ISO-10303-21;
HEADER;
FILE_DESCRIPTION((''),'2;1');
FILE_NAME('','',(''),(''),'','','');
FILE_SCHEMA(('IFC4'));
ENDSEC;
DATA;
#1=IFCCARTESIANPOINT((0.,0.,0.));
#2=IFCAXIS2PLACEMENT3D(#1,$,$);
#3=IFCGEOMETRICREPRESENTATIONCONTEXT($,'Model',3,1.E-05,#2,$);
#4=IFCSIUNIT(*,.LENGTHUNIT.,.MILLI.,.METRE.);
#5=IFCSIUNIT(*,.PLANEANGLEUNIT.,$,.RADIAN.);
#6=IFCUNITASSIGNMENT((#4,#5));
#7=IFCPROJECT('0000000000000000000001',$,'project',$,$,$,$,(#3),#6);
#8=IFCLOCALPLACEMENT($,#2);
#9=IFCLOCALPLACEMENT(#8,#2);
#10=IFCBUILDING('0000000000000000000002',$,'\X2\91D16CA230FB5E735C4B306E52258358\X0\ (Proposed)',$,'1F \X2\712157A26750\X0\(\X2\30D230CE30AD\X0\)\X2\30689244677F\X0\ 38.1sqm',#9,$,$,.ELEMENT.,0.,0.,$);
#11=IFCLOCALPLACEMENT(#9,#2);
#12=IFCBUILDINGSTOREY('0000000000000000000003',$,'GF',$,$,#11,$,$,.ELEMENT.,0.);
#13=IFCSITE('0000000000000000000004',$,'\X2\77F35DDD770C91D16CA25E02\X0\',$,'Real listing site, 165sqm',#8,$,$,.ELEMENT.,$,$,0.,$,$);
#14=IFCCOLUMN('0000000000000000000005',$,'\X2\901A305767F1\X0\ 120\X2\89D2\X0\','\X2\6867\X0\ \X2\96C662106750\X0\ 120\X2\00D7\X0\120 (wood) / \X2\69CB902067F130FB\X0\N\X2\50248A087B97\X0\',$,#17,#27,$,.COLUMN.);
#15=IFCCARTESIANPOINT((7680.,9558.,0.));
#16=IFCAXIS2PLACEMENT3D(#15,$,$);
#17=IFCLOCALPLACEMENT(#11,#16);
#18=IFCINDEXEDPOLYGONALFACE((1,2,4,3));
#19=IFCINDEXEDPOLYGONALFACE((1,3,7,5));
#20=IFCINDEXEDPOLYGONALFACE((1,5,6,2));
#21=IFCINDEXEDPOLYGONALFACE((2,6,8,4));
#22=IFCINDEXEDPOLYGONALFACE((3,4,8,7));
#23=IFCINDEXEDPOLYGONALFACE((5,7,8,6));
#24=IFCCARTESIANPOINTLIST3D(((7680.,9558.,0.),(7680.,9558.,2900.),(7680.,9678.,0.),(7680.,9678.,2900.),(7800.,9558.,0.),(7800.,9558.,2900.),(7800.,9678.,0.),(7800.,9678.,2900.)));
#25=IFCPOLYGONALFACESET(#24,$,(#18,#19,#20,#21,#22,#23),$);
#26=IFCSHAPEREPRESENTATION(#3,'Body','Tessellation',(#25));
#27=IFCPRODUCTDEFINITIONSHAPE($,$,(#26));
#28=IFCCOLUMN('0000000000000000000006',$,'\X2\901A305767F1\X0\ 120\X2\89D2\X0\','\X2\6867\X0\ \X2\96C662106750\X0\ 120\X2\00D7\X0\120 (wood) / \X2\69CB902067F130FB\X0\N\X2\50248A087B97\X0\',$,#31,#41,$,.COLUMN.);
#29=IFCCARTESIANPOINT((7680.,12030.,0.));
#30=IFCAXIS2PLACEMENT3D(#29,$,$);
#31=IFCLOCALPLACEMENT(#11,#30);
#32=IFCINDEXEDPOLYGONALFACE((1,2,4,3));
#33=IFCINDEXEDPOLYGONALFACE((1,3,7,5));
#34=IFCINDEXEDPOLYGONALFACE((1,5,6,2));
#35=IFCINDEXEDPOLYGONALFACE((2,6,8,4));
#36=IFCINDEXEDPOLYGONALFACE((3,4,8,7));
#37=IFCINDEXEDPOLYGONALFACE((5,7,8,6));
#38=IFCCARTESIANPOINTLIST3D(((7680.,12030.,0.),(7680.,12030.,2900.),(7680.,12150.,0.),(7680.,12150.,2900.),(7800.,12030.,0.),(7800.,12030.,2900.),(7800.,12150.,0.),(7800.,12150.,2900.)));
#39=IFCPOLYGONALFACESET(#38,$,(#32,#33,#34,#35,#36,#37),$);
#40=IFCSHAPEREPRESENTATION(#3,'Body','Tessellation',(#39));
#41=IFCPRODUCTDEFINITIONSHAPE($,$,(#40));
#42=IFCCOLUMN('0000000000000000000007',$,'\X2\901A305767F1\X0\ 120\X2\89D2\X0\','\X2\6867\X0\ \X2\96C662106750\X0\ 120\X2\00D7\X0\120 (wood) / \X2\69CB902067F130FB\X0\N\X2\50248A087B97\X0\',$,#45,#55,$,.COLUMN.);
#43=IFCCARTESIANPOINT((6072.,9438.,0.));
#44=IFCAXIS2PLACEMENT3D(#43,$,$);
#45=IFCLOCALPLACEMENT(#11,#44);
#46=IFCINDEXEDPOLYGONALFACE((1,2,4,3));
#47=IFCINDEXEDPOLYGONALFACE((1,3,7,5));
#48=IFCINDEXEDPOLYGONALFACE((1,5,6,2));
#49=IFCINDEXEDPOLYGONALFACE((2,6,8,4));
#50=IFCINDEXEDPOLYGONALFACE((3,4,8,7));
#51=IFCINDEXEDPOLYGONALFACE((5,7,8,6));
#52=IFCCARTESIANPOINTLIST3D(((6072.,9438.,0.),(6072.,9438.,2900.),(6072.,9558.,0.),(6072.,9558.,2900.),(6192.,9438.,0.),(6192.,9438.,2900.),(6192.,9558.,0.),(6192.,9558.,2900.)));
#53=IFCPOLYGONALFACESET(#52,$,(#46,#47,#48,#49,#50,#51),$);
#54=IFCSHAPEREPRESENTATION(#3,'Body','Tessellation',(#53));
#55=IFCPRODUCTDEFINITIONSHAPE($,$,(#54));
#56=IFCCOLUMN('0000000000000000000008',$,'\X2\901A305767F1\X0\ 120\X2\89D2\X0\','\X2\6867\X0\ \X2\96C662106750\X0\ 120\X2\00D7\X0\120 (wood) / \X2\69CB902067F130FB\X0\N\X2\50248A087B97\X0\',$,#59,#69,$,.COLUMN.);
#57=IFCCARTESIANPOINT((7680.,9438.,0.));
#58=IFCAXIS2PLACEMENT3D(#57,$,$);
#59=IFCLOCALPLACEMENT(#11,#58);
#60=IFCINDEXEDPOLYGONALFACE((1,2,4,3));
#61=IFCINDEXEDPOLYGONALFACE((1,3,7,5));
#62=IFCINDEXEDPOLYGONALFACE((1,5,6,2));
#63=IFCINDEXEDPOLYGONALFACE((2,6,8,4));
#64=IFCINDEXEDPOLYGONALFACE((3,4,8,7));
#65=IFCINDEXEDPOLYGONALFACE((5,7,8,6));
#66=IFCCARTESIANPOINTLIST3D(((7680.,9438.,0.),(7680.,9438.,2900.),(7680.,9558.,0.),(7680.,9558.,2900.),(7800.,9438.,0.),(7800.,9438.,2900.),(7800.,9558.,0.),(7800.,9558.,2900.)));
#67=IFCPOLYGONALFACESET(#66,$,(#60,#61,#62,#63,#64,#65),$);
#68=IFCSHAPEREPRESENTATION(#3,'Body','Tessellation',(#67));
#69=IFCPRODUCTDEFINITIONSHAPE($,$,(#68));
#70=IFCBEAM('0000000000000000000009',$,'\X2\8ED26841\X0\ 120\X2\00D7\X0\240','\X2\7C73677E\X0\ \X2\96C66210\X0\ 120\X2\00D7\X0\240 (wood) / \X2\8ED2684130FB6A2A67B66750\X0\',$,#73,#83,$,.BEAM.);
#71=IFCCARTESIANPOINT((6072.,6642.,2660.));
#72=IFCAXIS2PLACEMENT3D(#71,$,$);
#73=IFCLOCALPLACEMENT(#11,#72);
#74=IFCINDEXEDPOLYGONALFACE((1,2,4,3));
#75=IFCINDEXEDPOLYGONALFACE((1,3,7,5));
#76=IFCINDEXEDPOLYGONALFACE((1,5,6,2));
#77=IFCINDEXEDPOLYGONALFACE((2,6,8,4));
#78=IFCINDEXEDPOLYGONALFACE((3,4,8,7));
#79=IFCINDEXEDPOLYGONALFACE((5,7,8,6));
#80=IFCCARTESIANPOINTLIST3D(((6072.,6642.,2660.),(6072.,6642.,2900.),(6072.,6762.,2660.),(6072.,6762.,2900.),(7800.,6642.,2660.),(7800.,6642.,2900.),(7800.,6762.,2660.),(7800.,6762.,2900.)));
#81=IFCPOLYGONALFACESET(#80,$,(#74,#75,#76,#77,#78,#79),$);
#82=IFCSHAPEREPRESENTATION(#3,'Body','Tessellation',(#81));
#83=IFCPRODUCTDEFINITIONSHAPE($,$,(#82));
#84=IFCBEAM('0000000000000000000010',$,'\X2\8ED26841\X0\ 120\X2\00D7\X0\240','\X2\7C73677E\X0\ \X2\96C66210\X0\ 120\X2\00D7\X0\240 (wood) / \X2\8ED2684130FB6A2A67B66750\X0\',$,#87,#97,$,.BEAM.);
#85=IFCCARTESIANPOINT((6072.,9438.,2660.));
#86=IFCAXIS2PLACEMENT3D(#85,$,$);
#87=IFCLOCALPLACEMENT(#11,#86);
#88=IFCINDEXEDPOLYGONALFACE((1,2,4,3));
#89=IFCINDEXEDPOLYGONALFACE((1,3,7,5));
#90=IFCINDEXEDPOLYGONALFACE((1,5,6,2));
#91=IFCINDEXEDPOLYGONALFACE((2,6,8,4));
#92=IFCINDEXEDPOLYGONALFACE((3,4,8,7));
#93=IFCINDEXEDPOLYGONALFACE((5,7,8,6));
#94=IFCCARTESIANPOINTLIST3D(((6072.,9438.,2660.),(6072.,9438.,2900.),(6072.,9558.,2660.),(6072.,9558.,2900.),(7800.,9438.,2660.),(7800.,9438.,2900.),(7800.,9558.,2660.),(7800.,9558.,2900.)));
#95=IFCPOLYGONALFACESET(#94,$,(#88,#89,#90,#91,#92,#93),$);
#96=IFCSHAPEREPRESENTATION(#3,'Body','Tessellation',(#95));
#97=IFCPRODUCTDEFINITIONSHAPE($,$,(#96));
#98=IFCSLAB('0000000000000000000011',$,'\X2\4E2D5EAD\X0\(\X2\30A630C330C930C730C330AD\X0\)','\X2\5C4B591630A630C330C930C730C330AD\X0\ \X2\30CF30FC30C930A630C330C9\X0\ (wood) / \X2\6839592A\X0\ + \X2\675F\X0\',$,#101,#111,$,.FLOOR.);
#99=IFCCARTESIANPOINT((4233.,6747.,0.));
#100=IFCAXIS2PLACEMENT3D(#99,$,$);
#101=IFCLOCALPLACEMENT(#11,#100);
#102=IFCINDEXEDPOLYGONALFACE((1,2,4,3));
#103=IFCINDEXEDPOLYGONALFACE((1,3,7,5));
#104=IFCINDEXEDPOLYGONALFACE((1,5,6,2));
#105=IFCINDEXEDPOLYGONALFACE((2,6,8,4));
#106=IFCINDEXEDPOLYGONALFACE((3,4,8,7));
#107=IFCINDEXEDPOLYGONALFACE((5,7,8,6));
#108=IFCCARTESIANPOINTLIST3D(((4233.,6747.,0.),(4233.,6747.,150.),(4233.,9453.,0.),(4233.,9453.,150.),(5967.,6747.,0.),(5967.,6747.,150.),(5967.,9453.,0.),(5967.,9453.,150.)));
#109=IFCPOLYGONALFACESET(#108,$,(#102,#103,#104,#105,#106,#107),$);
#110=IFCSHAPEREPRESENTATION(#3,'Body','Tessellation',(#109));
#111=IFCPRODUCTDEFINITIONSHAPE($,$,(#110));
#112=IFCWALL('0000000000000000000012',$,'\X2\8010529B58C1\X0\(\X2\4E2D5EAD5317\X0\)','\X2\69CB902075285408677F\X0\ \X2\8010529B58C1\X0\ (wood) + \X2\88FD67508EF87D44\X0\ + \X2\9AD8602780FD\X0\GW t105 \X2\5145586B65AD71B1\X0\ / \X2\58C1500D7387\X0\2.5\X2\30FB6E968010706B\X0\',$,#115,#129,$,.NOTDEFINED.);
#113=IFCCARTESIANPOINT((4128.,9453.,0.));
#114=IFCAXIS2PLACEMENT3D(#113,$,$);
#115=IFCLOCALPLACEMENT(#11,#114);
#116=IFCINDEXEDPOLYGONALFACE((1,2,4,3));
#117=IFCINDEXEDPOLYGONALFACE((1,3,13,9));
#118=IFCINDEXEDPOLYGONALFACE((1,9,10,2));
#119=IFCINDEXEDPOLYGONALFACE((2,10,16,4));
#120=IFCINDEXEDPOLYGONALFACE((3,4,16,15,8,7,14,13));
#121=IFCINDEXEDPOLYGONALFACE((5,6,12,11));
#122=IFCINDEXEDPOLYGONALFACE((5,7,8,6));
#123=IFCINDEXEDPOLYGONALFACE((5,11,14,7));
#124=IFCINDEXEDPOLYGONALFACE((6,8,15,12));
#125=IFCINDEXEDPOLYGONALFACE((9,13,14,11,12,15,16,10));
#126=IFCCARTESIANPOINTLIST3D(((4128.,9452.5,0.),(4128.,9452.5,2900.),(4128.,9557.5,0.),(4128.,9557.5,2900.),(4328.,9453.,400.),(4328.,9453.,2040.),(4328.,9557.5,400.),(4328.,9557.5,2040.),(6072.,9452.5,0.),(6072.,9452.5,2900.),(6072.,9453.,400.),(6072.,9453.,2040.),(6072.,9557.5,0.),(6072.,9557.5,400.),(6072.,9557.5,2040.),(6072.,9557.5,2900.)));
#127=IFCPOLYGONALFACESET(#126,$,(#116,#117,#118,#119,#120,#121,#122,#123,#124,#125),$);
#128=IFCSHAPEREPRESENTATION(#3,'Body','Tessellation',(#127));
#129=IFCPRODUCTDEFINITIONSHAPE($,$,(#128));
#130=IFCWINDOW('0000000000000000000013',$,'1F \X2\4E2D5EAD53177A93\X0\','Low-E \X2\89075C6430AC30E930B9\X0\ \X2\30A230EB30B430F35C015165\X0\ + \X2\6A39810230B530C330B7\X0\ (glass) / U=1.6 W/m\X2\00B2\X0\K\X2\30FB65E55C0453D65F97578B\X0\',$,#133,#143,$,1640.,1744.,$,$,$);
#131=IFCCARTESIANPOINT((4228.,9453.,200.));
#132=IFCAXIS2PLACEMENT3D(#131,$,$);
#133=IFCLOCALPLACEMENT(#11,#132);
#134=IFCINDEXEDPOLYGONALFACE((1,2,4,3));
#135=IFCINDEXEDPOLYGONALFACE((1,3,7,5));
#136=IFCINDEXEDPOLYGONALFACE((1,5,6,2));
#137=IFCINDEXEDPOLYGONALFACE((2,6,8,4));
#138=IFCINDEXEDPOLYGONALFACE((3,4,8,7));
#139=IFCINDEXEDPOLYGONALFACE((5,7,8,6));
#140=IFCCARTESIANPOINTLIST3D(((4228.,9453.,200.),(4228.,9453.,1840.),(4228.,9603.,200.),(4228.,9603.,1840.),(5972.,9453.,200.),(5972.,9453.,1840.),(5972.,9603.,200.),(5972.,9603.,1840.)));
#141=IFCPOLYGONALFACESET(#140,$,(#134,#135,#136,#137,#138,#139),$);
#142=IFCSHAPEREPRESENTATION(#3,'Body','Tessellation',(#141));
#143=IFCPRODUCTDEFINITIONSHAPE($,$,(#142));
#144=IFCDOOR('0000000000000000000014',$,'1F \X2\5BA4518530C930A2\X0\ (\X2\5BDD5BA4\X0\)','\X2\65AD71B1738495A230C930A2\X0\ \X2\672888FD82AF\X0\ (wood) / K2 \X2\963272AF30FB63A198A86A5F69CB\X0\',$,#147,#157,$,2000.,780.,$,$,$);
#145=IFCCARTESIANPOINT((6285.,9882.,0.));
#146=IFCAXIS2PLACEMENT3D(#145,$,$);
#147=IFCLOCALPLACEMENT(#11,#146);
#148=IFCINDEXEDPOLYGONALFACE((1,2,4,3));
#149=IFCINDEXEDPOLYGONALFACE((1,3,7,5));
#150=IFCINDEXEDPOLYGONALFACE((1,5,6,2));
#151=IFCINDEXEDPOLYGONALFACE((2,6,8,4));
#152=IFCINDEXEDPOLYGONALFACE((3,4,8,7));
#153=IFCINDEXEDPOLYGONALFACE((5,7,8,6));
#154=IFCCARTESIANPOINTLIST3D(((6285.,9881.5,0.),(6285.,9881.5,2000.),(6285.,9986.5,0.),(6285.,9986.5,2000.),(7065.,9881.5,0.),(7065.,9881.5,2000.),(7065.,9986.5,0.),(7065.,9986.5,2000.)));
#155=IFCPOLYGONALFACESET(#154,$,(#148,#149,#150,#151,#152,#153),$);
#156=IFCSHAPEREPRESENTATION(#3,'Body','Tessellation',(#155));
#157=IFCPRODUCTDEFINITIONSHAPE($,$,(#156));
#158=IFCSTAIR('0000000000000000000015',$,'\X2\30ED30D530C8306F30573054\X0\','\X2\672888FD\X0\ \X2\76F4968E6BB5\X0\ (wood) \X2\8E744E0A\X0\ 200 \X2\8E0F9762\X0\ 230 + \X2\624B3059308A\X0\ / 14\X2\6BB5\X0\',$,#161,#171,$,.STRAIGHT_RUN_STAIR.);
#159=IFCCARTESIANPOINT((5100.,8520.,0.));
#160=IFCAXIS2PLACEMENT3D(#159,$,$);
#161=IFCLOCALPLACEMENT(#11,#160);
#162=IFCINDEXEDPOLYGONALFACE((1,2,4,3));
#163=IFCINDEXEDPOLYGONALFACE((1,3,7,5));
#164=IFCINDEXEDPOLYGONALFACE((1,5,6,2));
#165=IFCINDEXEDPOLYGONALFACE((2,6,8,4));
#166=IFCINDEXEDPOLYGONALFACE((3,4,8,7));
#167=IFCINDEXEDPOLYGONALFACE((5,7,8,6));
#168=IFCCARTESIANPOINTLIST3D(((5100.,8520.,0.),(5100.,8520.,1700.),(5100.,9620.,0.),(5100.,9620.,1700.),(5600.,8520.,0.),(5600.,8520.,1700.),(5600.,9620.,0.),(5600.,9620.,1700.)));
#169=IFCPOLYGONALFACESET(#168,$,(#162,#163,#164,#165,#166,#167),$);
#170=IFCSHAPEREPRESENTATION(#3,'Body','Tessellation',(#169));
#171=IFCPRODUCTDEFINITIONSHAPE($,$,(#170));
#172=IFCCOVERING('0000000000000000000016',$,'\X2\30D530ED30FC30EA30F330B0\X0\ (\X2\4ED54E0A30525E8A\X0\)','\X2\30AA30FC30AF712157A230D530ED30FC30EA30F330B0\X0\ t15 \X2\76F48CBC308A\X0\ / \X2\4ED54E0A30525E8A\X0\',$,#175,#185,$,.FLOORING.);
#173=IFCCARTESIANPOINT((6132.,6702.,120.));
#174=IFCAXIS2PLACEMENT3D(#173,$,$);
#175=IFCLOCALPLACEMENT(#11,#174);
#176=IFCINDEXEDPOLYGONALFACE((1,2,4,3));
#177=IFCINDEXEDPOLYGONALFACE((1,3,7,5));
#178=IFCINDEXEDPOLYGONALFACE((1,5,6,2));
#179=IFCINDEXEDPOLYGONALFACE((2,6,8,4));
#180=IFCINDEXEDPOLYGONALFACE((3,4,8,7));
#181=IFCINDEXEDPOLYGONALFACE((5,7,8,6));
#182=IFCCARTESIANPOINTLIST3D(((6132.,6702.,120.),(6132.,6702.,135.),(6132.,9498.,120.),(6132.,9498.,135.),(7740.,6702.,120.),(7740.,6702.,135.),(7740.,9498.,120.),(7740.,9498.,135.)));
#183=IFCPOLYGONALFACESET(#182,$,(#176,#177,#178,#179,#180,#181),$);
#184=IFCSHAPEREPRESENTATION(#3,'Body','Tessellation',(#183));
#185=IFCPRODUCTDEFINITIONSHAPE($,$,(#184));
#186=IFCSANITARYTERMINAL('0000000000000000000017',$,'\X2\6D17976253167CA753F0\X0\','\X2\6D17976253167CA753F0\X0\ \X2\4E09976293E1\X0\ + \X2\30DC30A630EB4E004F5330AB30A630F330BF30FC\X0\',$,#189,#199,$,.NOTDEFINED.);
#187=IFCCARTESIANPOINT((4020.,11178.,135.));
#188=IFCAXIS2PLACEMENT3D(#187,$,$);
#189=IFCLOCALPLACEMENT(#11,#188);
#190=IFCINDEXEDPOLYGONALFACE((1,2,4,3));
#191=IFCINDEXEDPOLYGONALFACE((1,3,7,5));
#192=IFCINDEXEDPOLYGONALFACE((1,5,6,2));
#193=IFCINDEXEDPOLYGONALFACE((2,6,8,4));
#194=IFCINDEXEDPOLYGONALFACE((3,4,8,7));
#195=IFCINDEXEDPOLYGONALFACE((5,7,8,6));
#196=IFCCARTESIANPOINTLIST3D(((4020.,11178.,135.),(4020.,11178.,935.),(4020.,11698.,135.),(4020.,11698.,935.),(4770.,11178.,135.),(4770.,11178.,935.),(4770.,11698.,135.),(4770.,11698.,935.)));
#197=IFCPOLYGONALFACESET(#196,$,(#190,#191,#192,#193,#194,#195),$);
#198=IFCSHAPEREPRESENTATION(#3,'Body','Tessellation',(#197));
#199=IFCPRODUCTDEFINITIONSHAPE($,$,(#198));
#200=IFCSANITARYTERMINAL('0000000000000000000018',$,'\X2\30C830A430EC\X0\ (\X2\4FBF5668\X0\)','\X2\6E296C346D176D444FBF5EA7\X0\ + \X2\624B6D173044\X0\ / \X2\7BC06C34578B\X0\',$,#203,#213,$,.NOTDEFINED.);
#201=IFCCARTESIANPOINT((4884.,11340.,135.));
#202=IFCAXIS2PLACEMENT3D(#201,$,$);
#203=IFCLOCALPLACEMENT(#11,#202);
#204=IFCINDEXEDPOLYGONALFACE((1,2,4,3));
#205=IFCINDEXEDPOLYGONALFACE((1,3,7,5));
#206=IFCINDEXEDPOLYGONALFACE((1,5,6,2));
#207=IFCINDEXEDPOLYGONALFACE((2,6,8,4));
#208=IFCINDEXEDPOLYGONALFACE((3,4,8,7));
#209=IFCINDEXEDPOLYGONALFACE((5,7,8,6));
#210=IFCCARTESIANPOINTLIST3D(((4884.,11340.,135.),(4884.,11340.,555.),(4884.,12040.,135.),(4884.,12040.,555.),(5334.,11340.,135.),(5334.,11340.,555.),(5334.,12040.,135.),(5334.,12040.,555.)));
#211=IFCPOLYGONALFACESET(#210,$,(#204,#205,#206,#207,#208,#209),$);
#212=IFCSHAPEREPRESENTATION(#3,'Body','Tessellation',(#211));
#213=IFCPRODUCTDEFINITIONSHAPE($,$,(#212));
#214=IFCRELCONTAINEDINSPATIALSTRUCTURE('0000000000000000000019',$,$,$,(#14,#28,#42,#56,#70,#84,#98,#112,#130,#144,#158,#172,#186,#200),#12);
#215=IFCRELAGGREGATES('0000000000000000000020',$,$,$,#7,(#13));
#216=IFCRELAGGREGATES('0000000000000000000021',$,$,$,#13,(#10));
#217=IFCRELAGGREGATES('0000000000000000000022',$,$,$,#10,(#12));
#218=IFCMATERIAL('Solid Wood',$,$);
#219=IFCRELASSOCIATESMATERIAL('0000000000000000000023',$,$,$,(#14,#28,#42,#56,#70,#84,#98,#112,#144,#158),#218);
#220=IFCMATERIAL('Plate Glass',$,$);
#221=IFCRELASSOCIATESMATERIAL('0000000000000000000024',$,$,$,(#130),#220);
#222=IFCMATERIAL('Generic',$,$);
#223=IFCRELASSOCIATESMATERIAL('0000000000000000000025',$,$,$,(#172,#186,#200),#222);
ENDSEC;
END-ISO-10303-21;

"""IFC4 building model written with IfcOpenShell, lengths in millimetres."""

from ifc_helpers import new_model, si_unit, frame, frame_2d, origin, place, context, project, spatial, rectangle, extrude, material, element, fill, save


model = new_model("IFC4")

# Units and contexts
model_context = context("Model", 3, precision=1e-05, world=origin())
ifc_project = project(units=[si_unit("LENGTHUNIT", "METRE", prefix="MILLI"), si_unit("PLANEANGLEUNIT", "RADIAN")], contexts=[model_context])

# Site, building, storey
site_placement = place(None, origin())
site = spatial("IfcSite", under=ifc_project, at=site_placement, Name="石川県金沢市", ObjectType="Real listing site, 165sqm", CompositionType="ELEMENT", RefElevation=0.0)
building_placement = place(site_placement, origin())
building = spatial("IfcBuilding", under=site, at=building_placement, Name="金沢・平屋の別荘 (Proposed)", ObjectType="1F 無垢材(ヒノキ)と鉄板 38.1sqm", CompositionType="ELEMENT", ElevationOfRefHeight=0.0, ElevationOfTerrain=0.0)
storey_placement = place(building_placement, origin())
storey = spatial("IfcBuildingStorey", under=building, at=storey_placement, Name="GF", CompositionType="ELEMENT", Elevation=0.0)

# Columns
ifc_material_1 = material(Name="Solid Wood")
column_1_placement = place(storey_placement, frame((7680.0, 9558.0, 0.0)))
element("IfcColumn", 1, at=column_1_placement, inside=storey, material=ifc_material_1, Name="通し柱 120角", Description="桧 集成材 120×120 (wood) / 構造柱・N値計算", PredefinedType="COLUMN", context=model_context, shape_type="SweptSolid", body=[
    extrude(rectangle(XDim=120.0, YDim=120.0, at=frame_2d((60.0, 60.0))), frame((7680.0, 9558.0, 0.0)), (0.0, 0.0, 1.0), 2900.0),
])
column_2_placement = place(storey_placement, frame((7680.0, 12030.0, 0.0)))
element("IfcColumn", 2, at=column_2_placement, inside=storey, material=ifc_material_1, Name="通し柱 120角", Description="桧 集成材 120×120 (wood) / 構造柱・N値計算", PredefinedType="COLUMN", context=model_context, shape_type="SweptSolid", body=[
    extrude(rectangle(XDim=120.0, YDim=120.0, at=frame_2d((60.0, 60.0))), frame((7680.0, 12030.0, 0.0)), (0.0, 0.0, 1.0), 2900.0),
])
column_3_placement = place(storey_placement, frame((6072.0, 9438.0, 0.0)))
element("IfcColumn", 3, at=column_3_placement, inside=storey, material=ifc_material_1, Name="通し柱 120角", Description="桧 集成材 120×120 (wood) / 構造柱・N値計算", PredefinedType="COLUMN", context=model_context, shape_type="SweptSolid", body=[
    extrude(rectangle(XDim=120.0, YDim=120.0, at=frame_2d((60.0, 60.0))), frame((6072.0, 9438.0, 0.0)), (0.0, 0.0, 1.0), 2900.0),
])
column_4_placement = place(storey_placement, frame((7680.0, 9438.0, 0.0)))
element("IfcColumn", 4, at=column_4_placement, inside=storey, material=ifc_material_1, Name="通し柱 120角", Description="桧 集成材 120×120 (wood) / 構造柱・N値計算", PredefinedType="COLUMN", context=model_context, shape_type="SweptSolid", body=[
    extrude(rectangle(XDim=120.0, YDim=120.0, at=frame_2d((60.0, 60.0))), frame((7680.0, 9438.0, 0.0)), (0.0, 0.0, 1.0), 2900.0),
])

# Beams
beam_1_placement = place(storey_placement, frame((6072.0, 6642.0, 2660.0)))
element("IfcBeam", 5, at=beam_1_placement, inside=storey, material=ifc_material_1, Name="軒桁 120×240", Description="米松 集成 120×240 (wood) / 軒桁・横架材", PredefinedType="BEAM", context=model_context, shape_type="SweptSolid", body=[
    extrude(rectangle(XDim=1728.0, YDim=120.0, at=frame_2d((864.0, 60.0))), frame((6072.0, 6642.0, 2660.0)), (0.0, 0.0, 1.0), 240.0),
])
beam_2_placement = place(storey_placement, frame((6072.0, 9438.0, 2660.0)))
element("IfcBeam", 6, at=beam_2_placement, inside=storey, material=ifc_material_1, Name="軒桁 120×240", Description="米松 集成 120×240 (wood) / 軒桁・横架材", PredefinedType="BEAM", context=model_context, shape_type="SweptSolid", body=[
    extrude(rectangle(XDim=1728.0, YDim=120.0, at=frame_2d((864.0, 60.0))), frame((6072.0, 9438.0, 2660.0)), (0.0, 0.0, 1.0), 240.0),
])

# Slab
slab_placement = place(storey_placement, frame((4233.0, 6747.0, 0.0)))
element("IfcSlab", 7, at=slab_placement, inside=storey, material=ifc_material_1, Name="中庭(ウッドデッキ)", Description="屋外ウッドデッキ ハードウッド (wood) / 根太 + 束", PredefinedType="FLOOR", context=model_context, shape_type="SweptSolid", body=[
    extrude(rectangle(XDim=1734.0, YDim=2706.0, at=frame_2d((867.0, 1353.0))), frame((4233.0, 6747.0, 0.0)), (0.0, 0.0, 1.0), 150.0),
])

# Wall, opening, window
wall_1_placement = place(storey_placement, frame((4128.0, 9453.0, 0.0)))
wall_1 = element("IfcWall", 8, at=wall_1_placement, inside=storey, material=ifc_material_1, Name="耐力壁(中庭北)", Description="構造用合板 耐力壁 (wood) + 製材軸組 + 高性能GW t105 充填断熱 / 壁倍率2.5・準耐火", PredefinedType="NOTDEFINED", context=model_context, shape_type="SweptSolid", body=[
    extrude(rectangle(XDim=1944.0, YDim=105.0, at=frame_2d((972.0, 52.0))), frame((4128.0, 9453.0, 0.0)), (0.0, 0.0, 1.0), 2900.0),
])
opening_placement = place(storey_placement, frame((4228.0, 9453.0, 200.0)))
opening = element("IfcOpeningElement", 9, at=opening_placement, cuts=wall_1, PredefinedType="NOTDEFINED", context=model_context, shape_type="SweptSolid", body=[
    extrude(rectangle(XDim=1744.0, YDim=150.0, at=frame_2d((872.0, 75.0))), frame((4228.0, 9453.0, 200.0)), (0.0, 0.0, 1.0), 1640.0),
])
ifc_material_2 = material(Name="Plate Glass")
window_placement = place(storey_placement, frame((4228.0, 9453.0, 200.0)))
window = element("IfcWindow", 10, at=window_placement, inside=storey, material=ifc_material_2, Name="1F 中庭北窓", Description="Low-E 複層ガラス アルゴン封入 + 樹脂サッシ (glass) / U=1.6 W/m²K・日射取得型", OverallHeight=1640.0, OverallWidth=1744.0, context=model_context, shape_type="SweptSolid", body=[
    extrude(rectangle(XDim=1744.0, YDim=150.0, at=frame_2d((872.0, 75.0))), frame((4228.0, 9453.0, 200.0)), (0.0, 0.0, 1.0), 1640.0),
])
fill(opening, window)

# Door
door_placement = place(storey_placement, frame((6285.0, 9882.0, 0.0)))
element("IfcDoor", 11, at=door_placement, inside=storey, material=ifc_material_1, Name="1F 室内ドア (寝室)", Description="断熱玄関ドア 木製芯 (wood) / K2 防犯・採風機構", OverallHeight=2000.0, OverallWidth=780.0, context=model_context, shape_type="SweptSolid", body=[
    extrude(rectangle(XDim=780.0, YDim=105.0, at=frame_2d((390.0, 52.0))), frame((6285.0, 9882.0, 0.0)), (0.0, 0.0, 1.0), 2000.0),
])

# Stair
stair_placement = place(storey_placement, frame((5100.0, 8520.0, 0.0)))
element("IfcStair", 12, at=stair_placement, inside=storey, material=ifc_material_1, Name="ロフトはしご", Description="木製 直階段 (wood) 蹴上 200 踏面 230 + 手すり / 14段", PredefinedType="STRAIGHT_RUN_STAIR", context=model_context, shape_type="SweptSolid", body=[
    extrude(rectangle(XDim=500.0, YDim=1100.0, at=frame_2d((250.0, 550.0))), frame((5100.0, 8520.0, 0.0)), (0.0, 0.0, 1.0), 1700.0),
])

# Covering
ifc_material_3 = material(Name="Generic")
covering_placement = place(storey_placement, frame((6132.0, 6702.0, 120.0)))
element("IfcCovering", 13, at=covering_placement, inside=storey, material=ifc_material_3, Name="フローリング (仕上げ床)", Description="オーク無垢フローリング t15 直貼り / 仕上げ床", PredefinedType="FLOORING", context=model_context, shape_type="SweptSolid", body=[
    extrude(rectangle(XDim=1608.0, YDim=2796.0, at=frame_2d((804.0, 1398.0))), frame((6132.0, 6702.0, 120.0)), (0.0, 0.0, 1.0), 15.0),
])

# Sanitary terminals
sanitary_terminal_1_placement = place(storey_placement, frame((4020.0, 11178.0, 135.0)))
element("IfcSanitaryTerminal", 14, at=sanitary_terminal_1_placement, inside=storey, material=ifc_material_3, Name="洗面化粧台", Description="洗面化粧台 三面鏡 + ボウル一体カウンター", PredefinedType="NOTDEFINED", context=model_context, shape_type="SweptSolid", body=[
    extrude(rectangle(XDim=750.0, YDim=520.0, at=frame_2d((375.0, 260.0))), frame((4020.0, 11178.0, 135.0)), (0.0, 0.0, 1.0), 800.0),
])
sanitary_terminal_2_placement = place(storey_placement, frame((4884.0, 11340.0, 135.0)))
element("IfcSanitaryTerminal", 15, at=sanitary_terminal_2_placement, inside=storey, material=ifc_material_3, Name="トイレ (便器)", Description="温水洗浄便座 + 手洗い / 節水型", PredefinedType="NOTDEFINED", context=model_context, shape_type="SweptSolid", body=[
    extrude(rectangle(XDim=450.0, YDim=700.0, at=frame_2d((225.0, 350.0))), frame((4884.0, 11340.0, 135.0)), (0.0, 0.0, 1.0), 420.0),
])

save(model, "model.ifc")
